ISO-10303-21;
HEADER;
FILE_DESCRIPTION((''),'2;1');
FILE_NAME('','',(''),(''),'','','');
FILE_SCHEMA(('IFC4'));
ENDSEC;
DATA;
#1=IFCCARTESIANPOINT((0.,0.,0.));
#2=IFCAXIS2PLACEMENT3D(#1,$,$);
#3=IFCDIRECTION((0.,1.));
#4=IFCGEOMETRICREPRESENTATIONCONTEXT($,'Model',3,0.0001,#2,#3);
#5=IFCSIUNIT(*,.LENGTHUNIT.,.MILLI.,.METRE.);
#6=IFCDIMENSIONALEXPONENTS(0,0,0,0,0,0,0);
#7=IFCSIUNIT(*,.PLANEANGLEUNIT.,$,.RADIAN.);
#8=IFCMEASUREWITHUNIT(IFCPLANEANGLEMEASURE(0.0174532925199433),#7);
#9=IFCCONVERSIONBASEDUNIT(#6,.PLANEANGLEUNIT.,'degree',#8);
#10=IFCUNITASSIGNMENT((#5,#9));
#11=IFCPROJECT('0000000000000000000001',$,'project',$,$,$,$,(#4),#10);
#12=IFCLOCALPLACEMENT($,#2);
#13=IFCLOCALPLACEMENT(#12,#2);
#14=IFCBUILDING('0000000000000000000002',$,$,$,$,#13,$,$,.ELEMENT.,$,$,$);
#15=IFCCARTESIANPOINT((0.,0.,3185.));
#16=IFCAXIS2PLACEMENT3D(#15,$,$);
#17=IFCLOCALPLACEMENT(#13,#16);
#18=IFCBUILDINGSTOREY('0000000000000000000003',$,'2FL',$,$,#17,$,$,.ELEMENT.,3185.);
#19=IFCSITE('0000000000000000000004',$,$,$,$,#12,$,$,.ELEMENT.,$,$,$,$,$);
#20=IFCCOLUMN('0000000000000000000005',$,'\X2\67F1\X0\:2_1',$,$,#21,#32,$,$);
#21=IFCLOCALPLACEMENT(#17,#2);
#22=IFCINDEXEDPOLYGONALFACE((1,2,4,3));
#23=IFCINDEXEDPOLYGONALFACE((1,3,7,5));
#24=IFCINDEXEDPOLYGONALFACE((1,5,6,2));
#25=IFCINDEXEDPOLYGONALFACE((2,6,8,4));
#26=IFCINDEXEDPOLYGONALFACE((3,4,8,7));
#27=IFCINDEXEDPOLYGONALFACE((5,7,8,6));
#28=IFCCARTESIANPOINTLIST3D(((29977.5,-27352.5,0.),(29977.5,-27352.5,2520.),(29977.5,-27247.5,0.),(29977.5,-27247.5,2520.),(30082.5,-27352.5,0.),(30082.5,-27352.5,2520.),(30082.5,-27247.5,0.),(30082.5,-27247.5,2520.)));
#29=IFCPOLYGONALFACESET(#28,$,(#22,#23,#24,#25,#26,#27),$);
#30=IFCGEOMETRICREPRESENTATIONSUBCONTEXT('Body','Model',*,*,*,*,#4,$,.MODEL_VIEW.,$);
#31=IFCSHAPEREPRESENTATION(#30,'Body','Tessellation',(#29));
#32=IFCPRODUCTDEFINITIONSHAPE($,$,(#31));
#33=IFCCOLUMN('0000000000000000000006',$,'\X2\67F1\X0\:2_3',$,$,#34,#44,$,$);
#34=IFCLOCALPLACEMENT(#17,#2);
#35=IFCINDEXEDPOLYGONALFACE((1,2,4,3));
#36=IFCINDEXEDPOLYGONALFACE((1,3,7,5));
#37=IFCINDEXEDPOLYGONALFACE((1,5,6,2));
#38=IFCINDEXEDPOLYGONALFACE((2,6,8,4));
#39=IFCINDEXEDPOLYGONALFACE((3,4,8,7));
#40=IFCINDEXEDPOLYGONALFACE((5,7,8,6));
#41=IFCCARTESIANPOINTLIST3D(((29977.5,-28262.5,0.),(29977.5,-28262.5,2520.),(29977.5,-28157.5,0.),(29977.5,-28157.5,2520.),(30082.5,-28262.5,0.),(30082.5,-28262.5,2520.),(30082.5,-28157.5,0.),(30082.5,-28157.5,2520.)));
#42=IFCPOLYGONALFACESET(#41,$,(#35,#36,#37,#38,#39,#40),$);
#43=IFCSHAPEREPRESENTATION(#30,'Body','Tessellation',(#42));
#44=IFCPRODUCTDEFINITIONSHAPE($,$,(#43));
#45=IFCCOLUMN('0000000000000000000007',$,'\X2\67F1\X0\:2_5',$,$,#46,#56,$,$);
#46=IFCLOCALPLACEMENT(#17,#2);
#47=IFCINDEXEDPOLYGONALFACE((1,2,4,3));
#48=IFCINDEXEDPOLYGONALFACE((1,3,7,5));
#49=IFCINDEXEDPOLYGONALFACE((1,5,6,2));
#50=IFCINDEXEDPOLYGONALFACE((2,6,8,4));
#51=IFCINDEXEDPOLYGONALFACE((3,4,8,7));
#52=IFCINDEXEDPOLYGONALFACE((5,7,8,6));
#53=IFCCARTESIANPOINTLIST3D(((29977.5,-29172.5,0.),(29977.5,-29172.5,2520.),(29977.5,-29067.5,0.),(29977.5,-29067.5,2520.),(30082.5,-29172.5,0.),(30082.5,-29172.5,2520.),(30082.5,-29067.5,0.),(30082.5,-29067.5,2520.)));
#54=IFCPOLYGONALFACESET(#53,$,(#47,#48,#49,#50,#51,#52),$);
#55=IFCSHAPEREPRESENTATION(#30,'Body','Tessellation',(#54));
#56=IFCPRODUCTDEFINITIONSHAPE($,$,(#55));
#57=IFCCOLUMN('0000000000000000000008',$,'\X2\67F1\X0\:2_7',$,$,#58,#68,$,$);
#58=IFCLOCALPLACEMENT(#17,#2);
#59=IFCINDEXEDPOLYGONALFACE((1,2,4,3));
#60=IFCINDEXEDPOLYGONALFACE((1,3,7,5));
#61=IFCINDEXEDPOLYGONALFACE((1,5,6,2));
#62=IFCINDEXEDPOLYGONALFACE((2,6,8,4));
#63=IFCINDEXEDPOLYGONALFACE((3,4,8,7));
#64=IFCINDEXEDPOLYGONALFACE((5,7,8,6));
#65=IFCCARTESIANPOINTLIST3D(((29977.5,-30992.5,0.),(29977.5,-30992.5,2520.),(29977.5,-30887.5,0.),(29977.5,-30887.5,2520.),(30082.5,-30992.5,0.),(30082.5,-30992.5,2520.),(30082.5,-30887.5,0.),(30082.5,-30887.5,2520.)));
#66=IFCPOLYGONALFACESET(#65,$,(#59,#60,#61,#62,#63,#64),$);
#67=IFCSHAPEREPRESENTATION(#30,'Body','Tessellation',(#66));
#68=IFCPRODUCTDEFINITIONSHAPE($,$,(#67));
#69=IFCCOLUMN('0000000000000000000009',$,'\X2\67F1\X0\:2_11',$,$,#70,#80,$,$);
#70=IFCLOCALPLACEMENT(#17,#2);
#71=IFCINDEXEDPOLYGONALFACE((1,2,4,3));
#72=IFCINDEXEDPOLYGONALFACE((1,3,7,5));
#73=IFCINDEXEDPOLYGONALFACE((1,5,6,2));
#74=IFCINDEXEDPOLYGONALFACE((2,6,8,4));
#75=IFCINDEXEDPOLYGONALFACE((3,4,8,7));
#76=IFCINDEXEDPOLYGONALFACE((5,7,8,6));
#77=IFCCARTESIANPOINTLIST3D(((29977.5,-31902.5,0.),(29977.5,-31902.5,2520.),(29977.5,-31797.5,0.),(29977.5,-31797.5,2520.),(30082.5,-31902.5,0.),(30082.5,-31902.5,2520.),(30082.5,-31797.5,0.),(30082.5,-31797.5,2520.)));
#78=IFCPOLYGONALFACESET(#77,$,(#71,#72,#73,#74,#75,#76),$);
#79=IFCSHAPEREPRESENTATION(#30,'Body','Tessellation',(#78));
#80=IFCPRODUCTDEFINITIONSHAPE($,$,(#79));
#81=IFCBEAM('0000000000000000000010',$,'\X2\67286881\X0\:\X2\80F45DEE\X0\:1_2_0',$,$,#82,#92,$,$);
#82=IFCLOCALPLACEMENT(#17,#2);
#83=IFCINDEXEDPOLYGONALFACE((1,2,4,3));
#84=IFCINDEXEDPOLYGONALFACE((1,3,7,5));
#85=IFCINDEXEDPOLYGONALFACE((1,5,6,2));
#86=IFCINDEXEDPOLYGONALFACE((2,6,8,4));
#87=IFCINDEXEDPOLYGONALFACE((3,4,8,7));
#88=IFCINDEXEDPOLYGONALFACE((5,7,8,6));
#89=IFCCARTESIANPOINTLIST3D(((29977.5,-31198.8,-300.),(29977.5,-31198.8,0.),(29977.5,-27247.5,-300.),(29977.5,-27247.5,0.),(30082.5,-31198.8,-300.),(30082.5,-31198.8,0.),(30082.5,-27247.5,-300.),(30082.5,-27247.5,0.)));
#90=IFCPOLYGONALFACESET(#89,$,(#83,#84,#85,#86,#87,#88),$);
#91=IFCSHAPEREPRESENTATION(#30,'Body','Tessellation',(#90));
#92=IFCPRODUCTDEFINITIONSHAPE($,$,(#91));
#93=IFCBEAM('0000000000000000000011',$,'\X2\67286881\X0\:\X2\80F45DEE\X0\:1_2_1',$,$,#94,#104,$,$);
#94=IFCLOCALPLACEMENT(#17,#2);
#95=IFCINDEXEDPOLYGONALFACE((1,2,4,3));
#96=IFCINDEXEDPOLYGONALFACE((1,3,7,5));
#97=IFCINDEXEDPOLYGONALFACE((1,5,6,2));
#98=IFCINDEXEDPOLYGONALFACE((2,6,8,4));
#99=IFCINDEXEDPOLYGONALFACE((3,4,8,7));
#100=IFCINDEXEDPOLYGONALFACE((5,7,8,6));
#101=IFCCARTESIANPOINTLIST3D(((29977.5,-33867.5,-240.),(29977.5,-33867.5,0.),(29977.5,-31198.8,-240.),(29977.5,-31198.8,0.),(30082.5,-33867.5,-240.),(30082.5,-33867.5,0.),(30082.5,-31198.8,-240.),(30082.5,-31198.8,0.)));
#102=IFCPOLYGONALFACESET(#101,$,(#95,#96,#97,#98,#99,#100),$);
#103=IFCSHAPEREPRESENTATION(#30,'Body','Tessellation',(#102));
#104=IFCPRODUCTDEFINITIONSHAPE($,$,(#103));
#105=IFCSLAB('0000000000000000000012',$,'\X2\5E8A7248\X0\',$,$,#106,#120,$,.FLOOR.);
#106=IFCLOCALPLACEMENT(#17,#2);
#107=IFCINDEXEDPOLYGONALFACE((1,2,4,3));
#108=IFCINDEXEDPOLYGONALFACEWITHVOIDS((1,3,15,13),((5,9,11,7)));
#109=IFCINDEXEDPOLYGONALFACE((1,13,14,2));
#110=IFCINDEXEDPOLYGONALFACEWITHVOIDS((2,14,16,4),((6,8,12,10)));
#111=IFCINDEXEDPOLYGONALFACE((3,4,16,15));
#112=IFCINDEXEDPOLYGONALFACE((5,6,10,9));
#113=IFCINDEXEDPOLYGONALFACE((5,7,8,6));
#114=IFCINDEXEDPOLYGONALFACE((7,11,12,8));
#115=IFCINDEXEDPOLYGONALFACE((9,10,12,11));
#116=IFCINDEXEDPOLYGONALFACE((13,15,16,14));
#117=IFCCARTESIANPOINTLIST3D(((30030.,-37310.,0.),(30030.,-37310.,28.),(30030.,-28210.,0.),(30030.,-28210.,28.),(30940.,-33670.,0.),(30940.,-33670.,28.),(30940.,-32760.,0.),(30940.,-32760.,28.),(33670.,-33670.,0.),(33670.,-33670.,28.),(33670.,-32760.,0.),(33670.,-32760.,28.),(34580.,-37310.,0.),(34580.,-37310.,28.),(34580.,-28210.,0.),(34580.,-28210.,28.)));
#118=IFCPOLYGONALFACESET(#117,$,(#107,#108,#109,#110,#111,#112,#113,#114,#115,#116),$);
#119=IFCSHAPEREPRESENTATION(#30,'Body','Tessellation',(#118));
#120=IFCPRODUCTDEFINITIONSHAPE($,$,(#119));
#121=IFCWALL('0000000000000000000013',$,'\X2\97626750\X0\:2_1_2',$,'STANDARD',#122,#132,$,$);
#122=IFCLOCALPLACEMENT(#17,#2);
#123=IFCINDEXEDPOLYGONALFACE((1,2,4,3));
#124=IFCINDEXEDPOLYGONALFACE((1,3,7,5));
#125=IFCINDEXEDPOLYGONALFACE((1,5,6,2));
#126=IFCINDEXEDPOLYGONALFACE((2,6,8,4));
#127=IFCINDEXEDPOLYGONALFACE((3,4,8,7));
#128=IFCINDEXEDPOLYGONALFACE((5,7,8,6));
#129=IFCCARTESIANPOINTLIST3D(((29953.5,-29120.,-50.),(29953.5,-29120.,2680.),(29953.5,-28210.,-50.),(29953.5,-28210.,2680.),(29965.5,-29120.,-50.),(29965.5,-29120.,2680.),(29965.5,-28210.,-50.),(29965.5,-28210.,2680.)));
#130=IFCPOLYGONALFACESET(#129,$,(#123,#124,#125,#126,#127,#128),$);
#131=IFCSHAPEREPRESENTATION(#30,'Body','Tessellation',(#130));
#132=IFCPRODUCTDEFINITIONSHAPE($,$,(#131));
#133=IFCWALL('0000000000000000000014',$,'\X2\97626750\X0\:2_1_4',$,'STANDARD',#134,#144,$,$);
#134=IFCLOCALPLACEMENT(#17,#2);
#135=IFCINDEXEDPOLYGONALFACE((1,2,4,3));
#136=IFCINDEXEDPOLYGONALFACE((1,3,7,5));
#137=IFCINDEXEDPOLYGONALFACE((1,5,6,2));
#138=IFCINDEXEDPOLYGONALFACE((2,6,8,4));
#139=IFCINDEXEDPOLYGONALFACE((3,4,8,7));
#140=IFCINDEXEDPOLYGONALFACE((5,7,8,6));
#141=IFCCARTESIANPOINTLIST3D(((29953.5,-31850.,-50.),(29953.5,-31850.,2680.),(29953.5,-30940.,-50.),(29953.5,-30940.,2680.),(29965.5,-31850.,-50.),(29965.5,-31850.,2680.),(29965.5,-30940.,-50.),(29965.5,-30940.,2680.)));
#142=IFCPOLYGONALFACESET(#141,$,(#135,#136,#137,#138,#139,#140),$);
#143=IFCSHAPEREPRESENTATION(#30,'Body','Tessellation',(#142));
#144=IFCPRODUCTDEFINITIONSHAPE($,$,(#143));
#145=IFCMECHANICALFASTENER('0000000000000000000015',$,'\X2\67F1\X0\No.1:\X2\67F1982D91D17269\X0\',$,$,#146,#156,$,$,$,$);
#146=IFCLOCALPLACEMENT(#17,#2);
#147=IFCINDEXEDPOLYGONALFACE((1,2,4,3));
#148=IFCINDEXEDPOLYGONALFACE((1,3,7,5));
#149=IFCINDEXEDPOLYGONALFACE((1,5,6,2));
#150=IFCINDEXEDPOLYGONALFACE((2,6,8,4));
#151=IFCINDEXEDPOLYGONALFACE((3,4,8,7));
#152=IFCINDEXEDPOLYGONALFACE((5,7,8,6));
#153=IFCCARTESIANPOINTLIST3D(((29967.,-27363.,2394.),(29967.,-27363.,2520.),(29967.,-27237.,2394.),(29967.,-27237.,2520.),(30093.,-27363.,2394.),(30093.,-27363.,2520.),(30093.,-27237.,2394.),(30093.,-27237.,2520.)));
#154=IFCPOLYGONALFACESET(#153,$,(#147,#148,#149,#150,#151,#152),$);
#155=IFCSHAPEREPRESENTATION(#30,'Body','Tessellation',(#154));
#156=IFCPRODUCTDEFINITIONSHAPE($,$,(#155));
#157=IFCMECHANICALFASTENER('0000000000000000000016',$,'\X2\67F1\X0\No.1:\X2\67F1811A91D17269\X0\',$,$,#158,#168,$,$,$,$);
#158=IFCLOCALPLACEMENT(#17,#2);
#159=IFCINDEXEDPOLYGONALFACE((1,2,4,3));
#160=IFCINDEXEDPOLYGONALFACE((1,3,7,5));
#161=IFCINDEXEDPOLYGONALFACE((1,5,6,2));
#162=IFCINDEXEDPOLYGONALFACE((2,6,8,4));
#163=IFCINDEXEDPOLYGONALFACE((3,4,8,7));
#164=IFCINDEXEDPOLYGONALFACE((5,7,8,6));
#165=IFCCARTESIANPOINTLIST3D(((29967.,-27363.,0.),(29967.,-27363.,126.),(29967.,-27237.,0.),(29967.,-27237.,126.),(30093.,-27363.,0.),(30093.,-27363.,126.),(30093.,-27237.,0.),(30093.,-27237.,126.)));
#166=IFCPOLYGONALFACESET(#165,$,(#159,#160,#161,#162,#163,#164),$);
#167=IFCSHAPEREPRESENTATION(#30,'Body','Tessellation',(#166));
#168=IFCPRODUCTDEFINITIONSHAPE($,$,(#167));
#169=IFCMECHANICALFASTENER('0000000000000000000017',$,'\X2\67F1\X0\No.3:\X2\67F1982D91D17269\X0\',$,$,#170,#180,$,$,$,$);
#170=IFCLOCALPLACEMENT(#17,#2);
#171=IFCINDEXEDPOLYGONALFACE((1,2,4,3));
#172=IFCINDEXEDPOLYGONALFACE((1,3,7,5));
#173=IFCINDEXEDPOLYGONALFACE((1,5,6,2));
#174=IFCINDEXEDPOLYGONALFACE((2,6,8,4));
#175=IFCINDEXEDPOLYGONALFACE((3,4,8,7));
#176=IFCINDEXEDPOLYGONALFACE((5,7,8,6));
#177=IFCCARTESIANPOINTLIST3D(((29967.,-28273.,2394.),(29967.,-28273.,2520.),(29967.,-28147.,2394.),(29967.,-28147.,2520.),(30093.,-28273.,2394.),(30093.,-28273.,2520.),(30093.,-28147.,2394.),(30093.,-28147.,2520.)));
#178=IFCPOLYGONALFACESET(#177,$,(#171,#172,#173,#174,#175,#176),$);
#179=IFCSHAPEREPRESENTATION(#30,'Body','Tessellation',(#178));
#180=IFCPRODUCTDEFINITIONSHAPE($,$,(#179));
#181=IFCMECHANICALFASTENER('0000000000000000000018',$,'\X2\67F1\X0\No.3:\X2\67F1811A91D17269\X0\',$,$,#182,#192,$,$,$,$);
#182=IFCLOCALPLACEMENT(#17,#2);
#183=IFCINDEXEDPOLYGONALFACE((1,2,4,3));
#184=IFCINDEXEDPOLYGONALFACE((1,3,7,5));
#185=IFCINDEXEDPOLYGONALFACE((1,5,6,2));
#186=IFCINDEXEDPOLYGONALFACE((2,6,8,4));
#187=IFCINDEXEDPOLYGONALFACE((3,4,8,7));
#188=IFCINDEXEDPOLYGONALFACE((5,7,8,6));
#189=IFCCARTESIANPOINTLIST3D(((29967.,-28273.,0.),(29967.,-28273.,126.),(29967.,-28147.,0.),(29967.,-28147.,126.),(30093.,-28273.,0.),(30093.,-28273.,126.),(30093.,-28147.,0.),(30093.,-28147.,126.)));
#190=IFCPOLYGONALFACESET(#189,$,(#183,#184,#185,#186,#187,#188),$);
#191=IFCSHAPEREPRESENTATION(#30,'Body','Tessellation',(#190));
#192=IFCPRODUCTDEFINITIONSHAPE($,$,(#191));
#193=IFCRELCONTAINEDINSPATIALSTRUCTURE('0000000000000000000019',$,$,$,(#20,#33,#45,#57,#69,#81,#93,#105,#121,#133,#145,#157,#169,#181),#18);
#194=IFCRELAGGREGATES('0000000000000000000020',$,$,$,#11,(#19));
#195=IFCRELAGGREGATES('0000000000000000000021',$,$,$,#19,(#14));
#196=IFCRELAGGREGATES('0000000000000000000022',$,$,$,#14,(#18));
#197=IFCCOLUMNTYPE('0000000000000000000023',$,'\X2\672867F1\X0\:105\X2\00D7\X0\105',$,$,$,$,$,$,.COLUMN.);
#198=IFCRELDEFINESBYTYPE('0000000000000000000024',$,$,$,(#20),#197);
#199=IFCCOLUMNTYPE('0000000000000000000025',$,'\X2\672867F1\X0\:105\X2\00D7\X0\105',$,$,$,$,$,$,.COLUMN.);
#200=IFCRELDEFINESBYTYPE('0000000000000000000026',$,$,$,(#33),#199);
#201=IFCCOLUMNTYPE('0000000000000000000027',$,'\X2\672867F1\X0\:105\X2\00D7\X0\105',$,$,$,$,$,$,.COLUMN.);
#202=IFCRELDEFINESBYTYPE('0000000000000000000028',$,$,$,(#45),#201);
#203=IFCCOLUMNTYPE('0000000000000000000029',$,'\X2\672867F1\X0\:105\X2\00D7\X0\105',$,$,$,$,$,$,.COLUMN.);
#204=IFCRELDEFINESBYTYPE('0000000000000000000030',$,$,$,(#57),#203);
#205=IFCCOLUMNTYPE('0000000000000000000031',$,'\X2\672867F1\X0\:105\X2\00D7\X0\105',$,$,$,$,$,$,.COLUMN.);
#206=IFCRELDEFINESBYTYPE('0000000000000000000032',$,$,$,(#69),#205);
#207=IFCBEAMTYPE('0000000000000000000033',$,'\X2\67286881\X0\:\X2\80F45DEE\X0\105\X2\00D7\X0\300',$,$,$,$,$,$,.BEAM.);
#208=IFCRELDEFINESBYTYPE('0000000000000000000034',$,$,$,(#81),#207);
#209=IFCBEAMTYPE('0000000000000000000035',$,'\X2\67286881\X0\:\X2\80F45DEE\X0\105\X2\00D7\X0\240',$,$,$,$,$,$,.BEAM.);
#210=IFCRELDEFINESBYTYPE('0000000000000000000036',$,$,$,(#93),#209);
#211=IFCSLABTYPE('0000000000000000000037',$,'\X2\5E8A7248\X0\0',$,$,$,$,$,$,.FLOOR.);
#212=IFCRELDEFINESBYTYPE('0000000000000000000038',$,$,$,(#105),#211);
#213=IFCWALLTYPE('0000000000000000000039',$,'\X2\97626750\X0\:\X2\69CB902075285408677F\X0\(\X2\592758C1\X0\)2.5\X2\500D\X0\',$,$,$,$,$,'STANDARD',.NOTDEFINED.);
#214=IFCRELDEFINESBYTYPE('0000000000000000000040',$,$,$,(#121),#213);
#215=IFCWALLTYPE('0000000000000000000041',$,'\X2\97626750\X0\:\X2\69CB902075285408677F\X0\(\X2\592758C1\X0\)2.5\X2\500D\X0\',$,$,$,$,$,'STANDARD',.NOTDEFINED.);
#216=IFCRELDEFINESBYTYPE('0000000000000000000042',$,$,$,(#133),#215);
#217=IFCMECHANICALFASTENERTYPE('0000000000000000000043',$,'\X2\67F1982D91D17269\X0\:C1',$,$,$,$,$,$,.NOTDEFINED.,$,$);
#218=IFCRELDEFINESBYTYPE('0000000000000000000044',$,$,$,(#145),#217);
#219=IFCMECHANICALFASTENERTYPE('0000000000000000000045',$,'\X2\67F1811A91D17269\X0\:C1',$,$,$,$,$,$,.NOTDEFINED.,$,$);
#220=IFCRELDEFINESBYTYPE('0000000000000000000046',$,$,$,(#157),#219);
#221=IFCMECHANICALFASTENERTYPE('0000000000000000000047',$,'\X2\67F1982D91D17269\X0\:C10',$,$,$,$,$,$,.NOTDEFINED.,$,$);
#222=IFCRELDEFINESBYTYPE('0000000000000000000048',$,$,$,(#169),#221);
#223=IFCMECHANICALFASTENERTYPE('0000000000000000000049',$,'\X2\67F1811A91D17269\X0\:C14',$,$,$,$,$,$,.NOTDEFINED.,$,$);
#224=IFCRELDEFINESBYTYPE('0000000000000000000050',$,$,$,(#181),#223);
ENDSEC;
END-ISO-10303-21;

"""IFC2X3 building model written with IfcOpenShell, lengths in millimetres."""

from ifc_helpers import new_model, entity, si_unit, converted_unit, direction, frame, origin, origin_with_axes, origin_2d, place, context, subcontext, project, spatial, polyline, rectangle, outline, extrude, type_object, element, save


model = new_model("IFC2X3")

# Units and contexts
model_context = context("Model", 3, precision=0.0001, world=origin(), true_north=direction((0.0, 1.0)))
body_context = subcontext(model_context, "Body", "Model", "MODEL_VIEW")
ifc_project = project(units=[si_unit("LENGTHUNIT", "METRE", prefix="MILLI"), converted_unit("PLANEANGLEUNIT", "degree", entity("IfcPlaneAngleMeasure", 0.0174532925199433), si_unit("PLANEANGLEUNIT", "RADIAN"), dimensions=[0, 0, 0, 0, 0, 0, 0])], contexts=[model_context])

# Site, building, storey
site_placement = place(None, origin())
site = spatial("IfcSite", under=ifc_project, at=site_placement, CompositionType="ELEMENT")
building_placement = place(site_placement, origin())
building = spatial("IfcBuilding", under=site, at=building_placement, CompositionType="ELEMENT")
storey_placement = place(building_placement, frame((0.0, 0.0, 3185.0)))
storey = spatial("IfcBuildingStorey", under=building, at=storey_placement, Name="2FL", CompositionType="ELEMENT", Elevation=3185.0)

# Columns
column_type_1 = type_object("IfcColumnType", Name="木柱:105×105", PredefinedType="COLUMN")
column_1_placement = place(storey_placement, frame((30030.0, -27300.0, 0.0)))
element("IfcColumn", 1, at=column_1_placement, inside=storey, type_object=column_type_1, Name="柱:2_1", context=body_context, shape_type="SweptSolid", body=[
    extrude(rectangle(XDim=105.0, YDim=105.0, at=origin_2d()), origin_with_axes(), (0.0, 0.0, 1.0), 2520.0),
])
column_type_2 = type_object("IfcColumnType", Name="木柱:105×105", PredefinedType="COLUMN")
column_2_placement = place(storey_placement, frame((30030.0, -28210.0, 0.0)))
element("IfcColumn", 2, at=column_2_placement, inside=storey, type_object=column_type_2, Name="柱:2_3", context=body_context, shape_type="SweptSolid", body=[
    extrude(rectangle(XDim=105.0, YDim=105.0, at=origin_2d()), origin_with_axes(), (0.0, 0.0, 1.0), 2520.0),
])
column_type_3 = type_object("IfcColumnType", Name="木柱:105×105", PredefinedType="COLUMN")
column_3_placement = place(storey_placement, frame((30030.0, -29120.0, 0.0)))
element("IfcColumn", 3, at=column_3_placement, inside=storey, type_object=column_type_3, Name="柱:2_5", context=body_context, shape_type="SweptSolid", body=[
    extrude(rectangle(XDim=105.0, YDim=105.0, at=origin_2d()), origin_with_axes(), (0.0, 0.0, 1.0), 2520.0),
])
column_type_4 = type_object("IfcColumnType", Name="木柱:105×105", PredefinedType="COLUMN")
column_4_placement = place(storey_placement, frame((30030.0, -30940.0, 0.0)))
element("IfcColumn", 4, at=column_4_placement, inside=storey, type_object=column_type_4, Name="柱:2_7", context=body_context, shape_type="SweptSolid", body=[
    extrude(rectangle(XDim=105.0, YDim=105.0, at=origin_2d()), origin_with_axes(), (0.0, 0.0, 1.0), 2520.0),
])
column_type_5 = type_object("IfcColumnType", Name="木柱:105×105", PredefinedType="COLUMN")
column_5_placement = place(storey_placement, frame((30030.0, -31850.0, 0.0)))
element("IfcColumn", 5, at=column_5_placement, inside=storey, type_object=column_type_5, Name="柱:2_11", context=body_context, shape_type="SweptSolid", body=[
    extrude(rectangle(XDim=105.0, YDim=105.0, at=origin_2d()), origin_with_axes(), (0.0, 0.0, 1.0), 2520.0),
])

# Beams
beam_type_1 = type_object("IfcBeamType", Name="木梁:胴差105×300", PredefinedType="BEAM")
beam_1_placement = place(storey_placement, frame((30030.0, -27247.5, -150.0), z_axis=(0.0, -1.0, 0.0), x_axis=(1.0, 0.0, 0.0)))
element("IfcBeam", 6, at=beam_1_placement, inside=storey, type_object=beam_type_1, Name="木梁:胴差:1_2_0", context=body_context, shape_type="SweptSolid", body=[
    extrude(rectangle(XDim=105.0, YDim=300.0, at=origin_2d()), origin_with_axes(), (0.0, 0.0, 1.0), 3951.3),
])
beam_type_2 = type_object("IfcBeamType", Name="木梁:胴差105×240", PredefinedType="BEAM")
beam_2_placement = place(storey_placement, frame((30030.0, -31198.8, -120.0), z_axis=(0.0, -1.0, 0.0), x_axis=(1.0, 0.0, 0.0)))
element("IfcBeam", 7, at=beam_2_placement, inside=storey, type_object=beam_type_2, Name="木梁:胴差:1_2_1", context=body_context, shape_type="SweptSolid", body=[
    extrude(rectangle(XDim=105.0, YDim=240.0, at=origin_2d()), origin_with_axes(), (0.0, 0.0, 1.0), 2668.6),
])

# Slab
slab_type = type_object("IfcSlabType", Name="床版0", PredefinedType="FLOOR")
slab_placement = place(storey_placement, origin_with_axes())
element("IfcSlab", 8, at=slab_placement, inside=storey, type_object=slab_type, Name="床版", PredefinedType="FLOOR", context=body_context, shape_type="SweptSolid", body=[
    extrude(outline(polyline([(30030.0, -28210.0, 0.0), (30030.0, -37310.0, 0.0), (34580.0, -37310.0, 0.0), (34580.0, -28210.0, 0.0), (30030.0, -28210.0, 0.0)]), holes=[polyline([(30940.0, -32760.0, 0.0), (30940.0, -33670.0, 0.0), (33670.0, -33670.0, 0.0), (33670.0, -32760.0, 0.0), (30940.0, -32760.0, 0.0)])]), origin_with_axes(), (0.0, 0.0, 1.0), 28.0),
])

# Walls
wall_type_1 = type_object("IfcWallType", Name="面材:構造用合板(大壁)2.5倍", ElementType="STANDARD", PredefinedType="NOTDEFINED")
wall_1_placement = place(storey_placement, frame((29965.5, -28665.0, -50.0), z_axis=(-1.0, 0.0, 0.0), x_axis=(0.0, -1.0, 0.0)))
element("IfcWall", 9, at=wall_1_placement, inside=storey, type_object=wall_type_1, Name="面材:2_1_2", ObjectType="STANDARD", context=body_context, shape_type="SweptSolid", body=[
    extrude(outline(polyline([(455.0, 0.0, 0.0), (-455.0, 0.0, 0.0), (-455.0, 2730.0, 0.0), (455.0, 2730.0, 0.0), (455.0, 0.0, 0.0)])), origin_with_axes(), (0.0, 0.0, 1.0), 12.0),
])
wall_type_2 = type_object("IfcWallType", Name="面材:構造用合板(大壁)2.5倍", ElementType="STANDARD", PredefinedType="NOTDEFINED")
wall_2_placement = place(storey_placement, frame((29965.5, -31395.0, -50.0), z_axis=(-1.0, 0.0, 0.0), x_axis=(0.0, -1.0, 0.0)))
element("IfcWall", 10, at=wall_2_placement, inside=storey, type_object=wall_type_2, Name="面材:2_1_4", ObjectType="STANDARD", context=body_context, shape_type="SweptSolid", body=[
    extrude(outline(polyline([(455.0, 0.0, 0.0), (-455.0, 0.0, 0.0), (-455.0, 2730.0, 0.0), (455.0, 2730.0, 0.0), (455.0, 0.0, 0.0)])), origin_with_axes(), (0.0, 0.0, 1.0), 12.0),
])

# Mechanical fasteners
mechanical_fastener_type_1 = type_object("IfcMechanicalFastenerType", Name="柱頭金物:C1")
mechanical_fastener_1_placement = place(storey_placement, frame((30030.0, -27300.0, 2394.0)))
element("IfcMechanicalFastener", 11, at=mechanical_fastener_1_placement, inside=storey, type_object=mechanical_fastener_type_1, Name="柱No.1:柱頭金物", context=body_context, shape_type="SweptSolid", body=[
    extrude(rectangle(XDim=126.0, YDim=126.0, at=origin_2d()), origin_with_axes(), (0.0, 0.0, 1.0), 126.0),
])
mechanical_fastener_type_2 = type_object("IfcMechanicalFastenerType", Name="柱脚金物:C1")
mechanical_fastener_2_placement = place(storey_placement, frame((30030.0, -27300.0, 0.0)))
element("IfcMechanicalFastener", 12, at=mechanical_fastener_2_placement, inside=storey, type_object=mechanical_fastener_type_2, Name="柱No.1:柱脚金物", context=body_context, shape_type="SweptSolid", body=[
    extrude(rectangle(XDim=126.0, YDim=126.0, at=origin_2d()), origin_with_axes(), (0.0, 0.0, 1.0), 126.0),
])
mechanical_fastener_type_3 = type_object("IfcMechanicalFastenerType", Name="柱頭金物:C10")
mechanical_fastener_3_placement = place(storey_placement, frame((30030.0, -28210.0, 2394.0)))
element("IfcMechanicalFastener", 13, at=mechanical_fastener_3_placement, inside=storey, type_object=mechanical_fastener_type_3, Name="柱No.3:柱頭金物", context=body_context, shape_type="SweptSolid", body=[
    extrude(rectangle(XDim=126.0, YDim=126.0, at=origin_2d()), origin_with_axes(), (0.0, 0.0, 1.0), 126.0),
])
mechanical_fastener_type_4 = type_object("IfcMechanicalFastenerType", Name="柱脚金物:C14")
mechanical_fastener_4_placement = place(storey_placement, frame((30030.0, -28210.0, 0.0)))
element("IfcMechanicalFastener", 14, at=mechanical_fastener_4_placement, inside=storey, type_object=mechanical_fastener_type_4, Name="柱No.3:柱脚金物", context=body_context, shape_type="SweptSolid", body=[
    extrude(rectangle(XDim=126.0, YDim=126.0, at=origin_2d()), origin_with_axes(), (0.0, 0.0, 1.0), 126.0),
])

save(model, "model.ifc")
